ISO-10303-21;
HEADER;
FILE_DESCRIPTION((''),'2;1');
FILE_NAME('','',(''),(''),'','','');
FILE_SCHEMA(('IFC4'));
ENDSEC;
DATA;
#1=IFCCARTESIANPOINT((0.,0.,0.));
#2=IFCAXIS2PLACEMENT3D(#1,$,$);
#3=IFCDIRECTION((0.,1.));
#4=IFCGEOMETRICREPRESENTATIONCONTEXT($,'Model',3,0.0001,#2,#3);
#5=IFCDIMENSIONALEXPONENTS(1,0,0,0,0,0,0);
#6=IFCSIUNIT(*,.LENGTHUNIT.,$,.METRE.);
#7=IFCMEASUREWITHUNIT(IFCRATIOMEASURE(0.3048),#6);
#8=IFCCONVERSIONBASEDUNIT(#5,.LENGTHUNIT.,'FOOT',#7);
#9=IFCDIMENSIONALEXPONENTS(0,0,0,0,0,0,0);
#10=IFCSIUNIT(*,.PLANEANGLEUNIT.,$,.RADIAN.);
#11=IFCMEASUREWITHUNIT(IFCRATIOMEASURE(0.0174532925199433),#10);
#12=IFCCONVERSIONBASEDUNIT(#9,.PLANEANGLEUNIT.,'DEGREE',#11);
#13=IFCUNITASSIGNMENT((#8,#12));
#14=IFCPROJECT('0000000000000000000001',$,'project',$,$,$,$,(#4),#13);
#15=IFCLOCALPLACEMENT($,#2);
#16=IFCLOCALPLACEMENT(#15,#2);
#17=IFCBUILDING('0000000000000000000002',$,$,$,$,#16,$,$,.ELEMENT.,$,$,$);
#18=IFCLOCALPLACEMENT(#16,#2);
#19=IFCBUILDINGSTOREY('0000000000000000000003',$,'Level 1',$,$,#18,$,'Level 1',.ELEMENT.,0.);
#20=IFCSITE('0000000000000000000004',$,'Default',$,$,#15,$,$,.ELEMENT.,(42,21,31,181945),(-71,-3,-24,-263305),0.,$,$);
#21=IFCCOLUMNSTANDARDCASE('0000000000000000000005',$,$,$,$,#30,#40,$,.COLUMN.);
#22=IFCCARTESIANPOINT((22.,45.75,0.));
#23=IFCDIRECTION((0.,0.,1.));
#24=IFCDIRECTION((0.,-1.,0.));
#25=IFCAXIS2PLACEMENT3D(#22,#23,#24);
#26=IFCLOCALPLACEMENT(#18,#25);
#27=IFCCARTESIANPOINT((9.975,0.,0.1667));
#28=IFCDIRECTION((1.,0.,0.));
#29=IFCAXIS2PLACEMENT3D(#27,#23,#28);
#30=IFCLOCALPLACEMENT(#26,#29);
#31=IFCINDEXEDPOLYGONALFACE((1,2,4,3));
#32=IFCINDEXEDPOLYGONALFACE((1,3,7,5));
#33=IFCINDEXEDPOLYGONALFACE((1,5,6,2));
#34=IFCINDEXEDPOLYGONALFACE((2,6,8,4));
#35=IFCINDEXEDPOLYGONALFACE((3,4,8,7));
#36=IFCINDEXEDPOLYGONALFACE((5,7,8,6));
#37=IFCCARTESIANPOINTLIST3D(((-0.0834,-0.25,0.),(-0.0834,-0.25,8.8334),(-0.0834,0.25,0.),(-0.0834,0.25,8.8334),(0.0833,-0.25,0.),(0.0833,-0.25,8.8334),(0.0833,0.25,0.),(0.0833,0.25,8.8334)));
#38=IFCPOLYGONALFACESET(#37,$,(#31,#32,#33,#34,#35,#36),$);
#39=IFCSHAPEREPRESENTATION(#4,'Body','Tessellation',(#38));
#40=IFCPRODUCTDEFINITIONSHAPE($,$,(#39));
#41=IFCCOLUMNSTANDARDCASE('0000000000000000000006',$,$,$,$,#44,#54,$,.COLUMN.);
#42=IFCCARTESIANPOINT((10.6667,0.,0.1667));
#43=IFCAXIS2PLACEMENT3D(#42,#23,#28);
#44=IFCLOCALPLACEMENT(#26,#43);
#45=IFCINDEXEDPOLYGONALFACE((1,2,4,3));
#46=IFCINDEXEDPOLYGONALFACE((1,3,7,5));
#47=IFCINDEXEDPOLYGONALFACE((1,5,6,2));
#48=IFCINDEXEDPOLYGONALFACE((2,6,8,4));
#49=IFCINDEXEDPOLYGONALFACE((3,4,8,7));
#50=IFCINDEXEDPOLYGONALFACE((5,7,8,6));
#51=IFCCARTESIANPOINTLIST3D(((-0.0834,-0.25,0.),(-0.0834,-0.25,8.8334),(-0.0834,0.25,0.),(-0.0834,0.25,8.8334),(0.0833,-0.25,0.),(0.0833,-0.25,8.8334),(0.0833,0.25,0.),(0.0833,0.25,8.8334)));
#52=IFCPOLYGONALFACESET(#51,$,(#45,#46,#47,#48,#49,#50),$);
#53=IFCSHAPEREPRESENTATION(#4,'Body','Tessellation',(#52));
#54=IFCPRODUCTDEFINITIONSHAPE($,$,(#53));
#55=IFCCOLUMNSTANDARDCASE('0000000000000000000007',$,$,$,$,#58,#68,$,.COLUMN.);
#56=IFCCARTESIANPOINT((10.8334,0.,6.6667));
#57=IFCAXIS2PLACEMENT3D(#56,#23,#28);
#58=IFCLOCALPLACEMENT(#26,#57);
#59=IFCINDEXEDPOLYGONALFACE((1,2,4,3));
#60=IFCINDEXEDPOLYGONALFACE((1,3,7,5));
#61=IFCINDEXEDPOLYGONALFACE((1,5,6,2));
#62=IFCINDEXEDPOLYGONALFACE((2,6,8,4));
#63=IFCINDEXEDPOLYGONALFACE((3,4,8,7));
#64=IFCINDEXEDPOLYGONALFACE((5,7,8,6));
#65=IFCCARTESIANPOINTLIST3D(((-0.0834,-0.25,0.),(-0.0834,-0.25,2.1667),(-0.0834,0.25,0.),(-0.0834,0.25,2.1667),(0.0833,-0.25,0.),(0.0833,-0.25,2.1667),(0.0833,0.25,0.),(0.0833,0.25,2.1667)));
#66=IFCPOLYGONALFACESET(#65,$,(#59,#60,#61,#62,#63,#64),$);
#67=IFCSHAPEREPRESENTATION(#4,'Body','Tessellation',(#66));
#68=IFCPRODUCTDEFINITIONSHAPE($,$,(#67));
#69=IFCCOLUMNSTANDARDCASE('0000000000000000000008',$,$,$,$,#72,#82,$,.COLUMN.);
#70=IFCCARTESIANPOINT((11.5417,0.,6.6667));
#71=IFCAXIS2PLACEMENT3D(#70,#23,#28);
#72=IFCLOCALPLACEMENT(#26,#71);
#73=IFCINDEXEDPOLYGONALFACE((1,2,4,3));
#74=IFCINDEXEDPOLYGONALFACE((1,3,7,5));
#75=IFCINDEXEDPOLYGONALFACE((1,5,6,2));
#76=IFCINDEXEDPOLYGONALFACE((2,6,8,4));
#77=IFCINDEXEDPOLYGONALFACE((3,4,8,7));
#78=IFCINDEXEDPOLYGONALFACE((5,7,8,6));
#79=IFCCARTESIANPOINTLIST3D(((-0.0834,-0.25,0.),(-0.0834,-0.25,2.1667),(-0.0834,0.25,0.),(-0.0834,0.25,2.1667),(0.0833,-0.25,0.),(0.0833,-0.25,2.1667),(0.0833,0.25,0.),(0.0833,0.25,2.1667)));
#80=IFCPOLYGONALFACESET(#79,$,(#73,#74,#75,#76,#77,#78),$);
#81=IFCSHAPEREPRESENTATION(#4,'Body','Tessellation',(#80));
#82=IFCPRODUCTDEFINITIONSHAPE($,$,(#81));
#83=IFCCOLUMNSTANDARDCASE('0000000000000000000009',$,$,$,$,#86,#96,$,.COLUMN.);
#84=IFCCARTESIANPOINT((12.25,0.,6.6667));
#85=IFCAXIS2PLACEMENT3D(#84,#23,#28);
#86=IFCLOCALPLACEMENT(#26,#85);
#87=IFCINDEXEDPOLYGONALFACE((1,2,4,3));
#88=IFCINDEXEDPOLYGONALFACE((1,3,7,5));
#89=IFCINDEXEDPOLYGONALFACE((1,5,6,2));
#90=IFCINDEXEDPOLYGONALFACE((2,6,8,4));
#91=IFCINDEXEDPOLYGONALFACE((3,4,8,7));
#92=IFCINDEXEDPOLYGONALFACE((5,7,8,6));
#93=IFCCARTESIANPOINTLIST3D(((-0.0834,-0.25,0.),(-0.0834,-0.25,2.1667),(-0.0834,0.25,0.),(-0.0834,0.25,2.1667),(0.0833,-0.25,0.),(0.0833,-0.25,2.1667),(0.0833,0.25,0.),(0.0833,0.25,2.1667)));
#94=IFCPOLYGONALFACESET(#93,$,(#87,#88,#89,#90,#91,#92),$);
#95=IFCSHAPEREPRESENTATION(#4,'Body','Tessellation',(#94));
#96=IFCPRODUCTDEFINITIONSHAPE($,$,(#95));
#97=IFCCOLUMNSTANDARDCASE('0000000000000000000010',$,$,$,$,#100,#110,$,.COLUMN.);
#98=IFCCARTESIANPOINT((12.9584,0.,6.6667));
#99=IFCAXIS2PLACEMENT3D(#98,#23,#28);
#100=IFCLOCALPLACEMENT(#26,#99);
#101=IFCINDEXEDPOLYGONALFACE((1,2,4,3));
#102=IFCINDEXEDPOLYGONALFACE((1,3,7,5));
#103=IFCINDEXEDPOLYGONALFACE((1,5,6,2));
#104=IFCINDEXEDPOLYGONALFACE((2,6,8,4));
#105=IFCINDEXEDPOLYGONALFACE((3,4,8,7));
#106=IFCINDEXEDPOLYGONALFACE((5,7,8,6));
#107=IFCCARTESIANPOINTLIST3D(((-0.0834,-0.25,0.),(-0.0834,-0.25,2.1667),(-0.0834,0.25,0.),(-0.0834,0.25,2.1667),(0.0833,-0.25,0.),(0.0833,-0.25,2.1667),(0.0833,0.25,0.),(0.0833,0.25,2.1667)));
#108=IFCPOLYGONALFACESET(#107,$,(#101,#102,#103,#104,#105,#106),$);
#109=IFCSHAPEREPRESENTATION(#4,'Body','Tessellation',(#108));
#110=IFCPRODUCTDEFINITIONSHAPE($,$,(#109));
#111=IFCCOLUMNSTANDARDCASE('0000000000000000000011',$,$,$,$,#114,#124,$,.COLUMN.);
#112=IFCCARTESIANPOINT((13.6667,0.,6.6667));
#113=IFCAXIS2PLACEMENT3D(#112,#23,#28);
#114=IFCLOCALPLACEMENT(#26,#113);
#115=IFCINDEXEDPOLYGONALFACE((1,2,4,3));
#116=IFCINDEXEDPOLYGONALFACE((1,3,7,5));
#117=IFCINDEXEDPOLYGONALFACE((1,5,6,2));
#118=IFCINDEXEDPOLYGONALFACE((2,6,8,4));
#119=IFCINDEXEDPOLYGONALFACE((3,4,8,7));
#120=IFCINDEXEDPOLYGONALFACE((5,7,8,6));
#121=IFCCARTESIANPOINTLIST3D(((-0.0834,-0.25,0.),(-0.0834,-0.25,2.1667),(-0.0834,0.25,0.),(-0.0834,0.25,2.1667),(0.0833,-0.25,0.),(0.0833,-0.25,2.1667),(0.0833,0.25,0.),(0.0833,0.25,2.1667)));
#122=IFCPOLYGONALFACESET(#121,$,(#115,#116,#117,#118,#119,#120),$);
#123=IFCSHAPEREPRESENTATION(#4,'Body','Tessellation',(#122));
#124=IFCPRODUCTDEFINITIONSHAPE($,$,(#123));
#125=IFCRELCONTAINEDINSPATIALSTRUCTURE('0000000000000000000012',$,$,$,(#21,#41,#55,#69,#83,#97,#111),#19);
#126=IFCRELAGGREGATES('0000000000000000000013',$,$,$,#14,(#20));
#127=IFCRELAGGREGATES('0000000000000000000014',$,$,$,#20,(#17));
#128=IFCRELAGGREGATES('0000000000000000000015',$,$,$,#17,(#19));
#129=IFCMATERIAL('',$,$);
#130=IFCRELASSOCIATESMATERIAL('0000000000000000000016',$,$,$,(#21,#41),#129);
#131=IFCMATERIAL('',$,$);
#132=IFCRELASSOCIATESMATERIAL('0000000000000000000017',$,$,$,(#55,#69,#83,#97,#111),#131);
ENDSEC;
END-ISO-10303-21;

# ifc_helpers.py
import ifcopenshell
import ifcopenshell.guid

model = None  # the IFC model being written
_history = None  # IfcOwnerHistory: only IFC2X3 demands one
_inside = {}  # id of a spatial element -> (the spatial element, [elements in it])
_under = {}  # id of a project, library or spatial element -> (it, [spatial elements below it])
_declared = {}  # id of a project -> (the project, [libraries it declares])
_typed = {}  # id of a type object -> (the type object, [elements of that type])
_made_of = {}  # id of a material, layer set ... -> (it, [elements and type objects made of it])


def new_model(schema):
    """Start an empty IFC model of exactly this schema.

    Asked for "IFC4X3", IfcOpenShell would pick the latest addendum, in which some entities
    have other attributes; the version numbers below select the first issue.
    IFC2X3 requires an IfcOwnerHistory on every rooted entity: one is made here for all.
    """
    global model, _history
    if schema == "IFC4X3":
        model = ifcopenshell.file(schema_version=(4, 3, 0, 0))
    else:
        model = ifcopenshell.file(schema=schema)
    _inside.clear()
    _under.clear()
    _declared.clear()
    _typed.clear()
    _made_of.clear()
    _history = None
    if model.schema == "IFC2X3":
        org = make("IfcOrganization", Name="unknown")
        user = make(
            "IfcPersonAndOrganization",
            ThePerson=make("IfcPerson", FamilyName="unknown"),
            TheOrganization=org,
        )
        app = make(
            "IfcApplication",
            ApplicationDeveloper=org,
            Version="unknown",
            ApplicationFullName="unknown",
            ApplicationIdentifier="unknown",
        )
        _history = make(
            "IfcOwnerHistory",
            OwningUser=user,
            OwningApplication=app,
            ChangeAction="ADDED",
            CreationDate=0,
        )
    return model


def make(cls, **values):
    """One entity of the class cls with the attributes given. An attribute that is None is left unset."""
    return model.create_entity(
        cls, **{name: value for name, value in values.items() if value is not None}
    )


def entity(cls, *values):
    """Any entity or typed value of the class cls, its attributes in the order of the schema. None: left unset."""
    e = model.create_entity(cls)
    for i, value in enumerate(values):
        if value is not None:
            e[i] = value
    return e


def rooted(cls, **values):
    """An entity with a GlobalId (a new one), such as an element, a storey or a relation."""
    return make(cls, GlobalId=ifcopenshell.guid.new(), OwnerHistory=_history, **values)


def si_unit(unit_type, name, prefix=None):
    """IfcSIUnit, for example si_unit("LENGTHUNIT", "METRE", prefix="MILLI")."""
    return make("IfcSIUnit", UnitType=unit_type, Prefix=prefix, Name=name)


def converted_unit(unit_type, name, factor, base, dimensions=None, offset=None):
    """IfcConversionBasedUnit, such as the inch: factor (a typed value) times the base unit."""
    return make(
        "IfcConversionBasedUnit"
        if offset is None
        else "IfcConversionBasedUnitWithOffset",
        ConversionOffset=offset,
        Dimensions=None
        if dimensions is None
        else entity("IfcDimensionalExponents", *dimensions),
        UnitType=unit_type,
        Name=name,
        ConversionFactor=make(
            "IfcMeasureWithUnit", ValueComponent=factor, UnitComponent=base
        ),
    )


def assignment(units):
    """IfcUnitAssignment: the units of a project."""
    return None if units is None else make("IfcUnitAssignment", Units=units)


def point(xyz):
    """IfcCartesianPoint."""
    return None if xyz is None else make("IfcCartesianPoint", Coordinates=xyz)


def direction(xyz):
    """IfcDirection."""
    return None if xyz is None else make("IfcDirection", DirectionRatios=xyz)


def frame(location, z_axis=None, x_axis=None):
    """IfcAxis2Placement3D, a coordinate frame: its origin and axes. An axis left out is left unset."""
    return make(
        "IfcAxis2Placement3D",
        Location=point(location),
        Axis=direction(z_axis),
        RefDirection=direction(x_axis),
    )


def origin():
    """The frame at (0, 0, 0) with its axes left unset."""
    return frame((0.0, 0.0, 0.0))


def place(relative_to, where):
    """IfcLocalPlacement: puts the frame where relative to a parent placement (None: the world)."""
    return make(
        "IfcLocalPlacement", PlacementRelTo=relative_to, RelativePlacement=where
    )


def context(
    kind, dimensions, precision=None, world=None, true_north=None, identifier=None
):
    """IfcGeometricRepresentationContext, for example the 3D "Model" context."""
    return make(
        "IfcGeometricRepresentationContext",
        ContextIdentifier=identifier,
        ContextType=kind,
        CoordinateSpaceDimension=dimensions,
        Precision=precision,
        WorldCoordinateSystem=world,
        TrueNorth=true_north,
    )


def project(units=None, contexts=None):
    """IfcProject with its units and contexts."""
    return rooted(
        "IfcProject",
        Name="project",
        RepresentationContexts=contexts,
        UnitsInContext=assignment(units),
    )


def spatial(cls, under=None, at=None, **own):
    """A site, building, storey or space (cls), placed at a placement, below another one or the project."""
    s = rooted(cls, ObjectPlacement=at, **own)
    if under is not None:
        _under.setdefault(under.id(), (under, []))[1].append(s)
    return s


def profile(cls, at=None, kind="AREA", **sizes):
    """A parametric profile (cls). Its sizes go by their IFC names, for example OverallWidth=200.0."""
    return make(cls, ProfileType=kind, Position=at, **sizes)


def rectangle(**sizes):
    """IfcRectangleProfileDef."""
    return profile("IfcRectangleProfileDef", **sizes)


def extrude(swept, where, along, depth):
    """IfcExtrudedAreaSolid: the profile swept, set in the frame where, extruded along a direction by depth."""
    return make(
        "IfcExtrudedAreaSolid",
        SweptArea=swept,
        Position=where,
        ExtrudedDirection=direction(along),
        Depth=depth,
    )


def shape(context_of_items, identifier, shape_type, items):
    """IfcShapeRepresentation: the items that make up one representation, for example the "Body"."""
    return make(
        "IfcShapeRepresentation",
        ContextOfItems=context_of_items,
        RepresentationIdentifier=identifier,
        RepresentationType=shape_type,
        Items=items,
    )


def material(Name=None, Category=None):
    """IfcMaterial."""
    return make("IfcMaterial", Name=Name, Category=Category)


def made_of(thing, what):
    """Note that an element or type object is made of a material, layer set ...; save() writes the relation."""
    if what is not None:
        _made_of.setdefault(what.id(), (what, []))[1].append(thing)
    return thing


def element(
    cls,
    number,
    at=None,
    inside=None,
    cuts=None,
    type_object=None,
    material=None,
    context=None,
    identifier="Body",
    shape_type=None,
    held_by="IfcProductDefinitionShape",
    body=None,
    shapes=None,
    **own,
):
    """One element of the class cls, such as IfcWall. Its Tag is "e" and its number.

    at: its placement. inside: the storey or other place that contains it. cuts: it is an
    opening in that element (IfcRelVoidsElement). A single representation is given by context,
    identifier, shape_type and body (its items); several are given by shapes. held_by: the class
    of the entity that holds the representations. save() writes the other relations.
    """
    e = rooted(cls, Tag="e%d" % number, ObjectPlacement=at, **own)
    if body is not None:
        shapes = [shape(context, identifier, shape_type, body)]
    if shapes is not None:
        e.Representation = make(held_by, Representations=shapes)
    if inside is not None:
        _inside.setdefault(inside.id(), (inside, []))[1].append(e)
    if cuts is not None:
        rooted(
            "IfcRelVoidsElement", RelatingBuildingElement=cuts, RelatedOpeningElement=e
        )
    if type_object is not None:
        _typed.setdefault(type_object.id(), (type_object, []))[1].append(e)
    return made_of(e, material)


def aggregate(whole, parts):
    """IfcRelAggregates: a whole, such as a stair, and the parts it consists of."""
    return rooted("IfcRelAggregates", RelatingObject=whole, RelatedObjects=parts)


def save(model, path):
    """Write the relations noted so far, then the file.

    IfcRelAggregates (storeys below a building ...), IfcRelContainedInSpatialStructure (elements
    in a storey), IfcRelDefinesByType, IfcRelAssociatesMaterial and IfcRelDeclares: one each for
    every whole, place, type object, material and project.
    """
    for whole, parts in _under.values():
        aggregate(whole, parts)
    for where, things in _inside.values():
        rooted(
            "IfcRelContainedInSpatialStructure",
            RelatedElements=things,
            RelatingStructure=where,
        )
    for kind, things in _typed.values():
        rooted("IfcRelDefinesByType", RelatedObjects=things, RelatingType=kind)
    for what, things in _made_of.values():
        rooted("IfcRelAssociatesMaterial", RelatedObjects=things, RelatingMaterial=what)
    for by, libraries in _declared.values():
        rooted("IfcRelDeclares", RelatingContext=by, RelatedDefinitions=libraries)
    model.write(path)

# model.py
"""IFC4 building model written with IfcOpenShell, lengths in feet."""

from ifc_helpers import new_model, entity, si_unit, converted_unit, direction, frame, origin, place, context, project, spatial, rectangle, extrude, material, element, save


model = new_model("IFC4")

# Units and contexts
model_context = context("Model", 3, precision=0.0001, world=origin(), true_north=direction((0.0, 1.0)))
ifc_project = project(units=[converted_unit("LENGTHUNIT", "FOOT", entity("IfcRatioMeasure", 0.3048), si_unit("LENGTHUNIT", "METRE"), dimensions=[1, 0, 0, 0, 0, 0, 0]), converted_unit("PLANEANGLEUNIT", "DEGREE", entity("IfcRatioMeasure", 0.0174532925199433), si_unit("PLANEANGLEUNIT", "RADIAN"), dimensions=[0, 0, 0, 0, 0, 0, 0])], contexts=[model_context])

# Site, building, storey
site_placement = place(None, origin())
site = spatial("IfcSite", under=ifc_project, at=site_placement, Name="Default", CompositionType="ELEMENT", RefLatitude=(42, 21, 31, 181945), RefLongitude=(-71, -3, -24, -263305), RefElevation=0.0)
building_placement = place(site_placement, origin())
building = spatial("IfcBuilding", under=site, at=building_placement, CompositionType="ELEMENT")
storey_placement = place(building_placement, origin())
storey = spatial("IfcBuildingStorey", under=building, at=storey_placement, Name="Level 1", LongName="Level 1", CompositionType="ELEMENT", Elevation=0.0)

# Columns
placement_1 = place(storey_placement, frame((22.0, 45.75, 0.0), z_axis=(0.0, 0.0, 1.0), x_axis=(0.0, -1.0, 0.0)))
ifc_material_1 = material(Name="")
for number, where, z_axis, x_axis in (
    (1, (9.975, 0.0, 0.1667), (0.0, 0.0, 1.0), (1.0, 0.0, 0.0)),
    (2, (10.6667, 0.0, 0.1667), (0.0, 0.0, 1.0), (1.0, 0.0, 0.0)),
):
    element("IfcColumnStandardCase", number, at=place(placement_1, frame(where, z_axis=z_axis, x_axis=x_axis)), inside=storey, material=ifc_material_1, PredefinedType="COLUMN", context=model_context, shape_type="SweptSolid", body=[
        extrude(rectangle(XDim=0.1667, YDim=0.5), origin(), (0.0, 0.0, 1.0), 8.8334),
    ])
ifc_material_2 = material(Name="")
for number, where, z_axis, x_axis in (
    (3, (10.8334, 0.0, 6.6667), (0.0, 0.0, 1.0), (1.0, 0.0, 0.0)),
    (4, (11.5417, 0.0, 6.6667), (0.0, 0.0, 1.0), (1.0, 0.0, 0.0)),
    (5, (12.25, 0.0, 6.6667), (0.0, 0.0, 1.0), (1.0, 0.0, 0.0)),
    (6, (12.9584, 0.0, 6.6667), (0.0, 0.0, 1.0), (1.0, 0.0, 0.0)),
    (7, (13.6667, 0.0, 6.6667), (0.0, 0.0, 1.0), (1.0, 0.0, 0.0)),
):
    element("IfcColumnStandardCase", number, at=place(placement_1, frame(where, z_axis=z_axis, x_axis=x_axis)), inside=storey, material=ifc_material_2, PredefinedType="COLUMN", context=model_context, shape_type="SweptSolid", body=[
        extrude(rectangle(XDim=0.1667, YDim=0.5), origin(), (0.0, 0.0, 1.0), 2.1667),
    ])

save(model, "model.ifc")
